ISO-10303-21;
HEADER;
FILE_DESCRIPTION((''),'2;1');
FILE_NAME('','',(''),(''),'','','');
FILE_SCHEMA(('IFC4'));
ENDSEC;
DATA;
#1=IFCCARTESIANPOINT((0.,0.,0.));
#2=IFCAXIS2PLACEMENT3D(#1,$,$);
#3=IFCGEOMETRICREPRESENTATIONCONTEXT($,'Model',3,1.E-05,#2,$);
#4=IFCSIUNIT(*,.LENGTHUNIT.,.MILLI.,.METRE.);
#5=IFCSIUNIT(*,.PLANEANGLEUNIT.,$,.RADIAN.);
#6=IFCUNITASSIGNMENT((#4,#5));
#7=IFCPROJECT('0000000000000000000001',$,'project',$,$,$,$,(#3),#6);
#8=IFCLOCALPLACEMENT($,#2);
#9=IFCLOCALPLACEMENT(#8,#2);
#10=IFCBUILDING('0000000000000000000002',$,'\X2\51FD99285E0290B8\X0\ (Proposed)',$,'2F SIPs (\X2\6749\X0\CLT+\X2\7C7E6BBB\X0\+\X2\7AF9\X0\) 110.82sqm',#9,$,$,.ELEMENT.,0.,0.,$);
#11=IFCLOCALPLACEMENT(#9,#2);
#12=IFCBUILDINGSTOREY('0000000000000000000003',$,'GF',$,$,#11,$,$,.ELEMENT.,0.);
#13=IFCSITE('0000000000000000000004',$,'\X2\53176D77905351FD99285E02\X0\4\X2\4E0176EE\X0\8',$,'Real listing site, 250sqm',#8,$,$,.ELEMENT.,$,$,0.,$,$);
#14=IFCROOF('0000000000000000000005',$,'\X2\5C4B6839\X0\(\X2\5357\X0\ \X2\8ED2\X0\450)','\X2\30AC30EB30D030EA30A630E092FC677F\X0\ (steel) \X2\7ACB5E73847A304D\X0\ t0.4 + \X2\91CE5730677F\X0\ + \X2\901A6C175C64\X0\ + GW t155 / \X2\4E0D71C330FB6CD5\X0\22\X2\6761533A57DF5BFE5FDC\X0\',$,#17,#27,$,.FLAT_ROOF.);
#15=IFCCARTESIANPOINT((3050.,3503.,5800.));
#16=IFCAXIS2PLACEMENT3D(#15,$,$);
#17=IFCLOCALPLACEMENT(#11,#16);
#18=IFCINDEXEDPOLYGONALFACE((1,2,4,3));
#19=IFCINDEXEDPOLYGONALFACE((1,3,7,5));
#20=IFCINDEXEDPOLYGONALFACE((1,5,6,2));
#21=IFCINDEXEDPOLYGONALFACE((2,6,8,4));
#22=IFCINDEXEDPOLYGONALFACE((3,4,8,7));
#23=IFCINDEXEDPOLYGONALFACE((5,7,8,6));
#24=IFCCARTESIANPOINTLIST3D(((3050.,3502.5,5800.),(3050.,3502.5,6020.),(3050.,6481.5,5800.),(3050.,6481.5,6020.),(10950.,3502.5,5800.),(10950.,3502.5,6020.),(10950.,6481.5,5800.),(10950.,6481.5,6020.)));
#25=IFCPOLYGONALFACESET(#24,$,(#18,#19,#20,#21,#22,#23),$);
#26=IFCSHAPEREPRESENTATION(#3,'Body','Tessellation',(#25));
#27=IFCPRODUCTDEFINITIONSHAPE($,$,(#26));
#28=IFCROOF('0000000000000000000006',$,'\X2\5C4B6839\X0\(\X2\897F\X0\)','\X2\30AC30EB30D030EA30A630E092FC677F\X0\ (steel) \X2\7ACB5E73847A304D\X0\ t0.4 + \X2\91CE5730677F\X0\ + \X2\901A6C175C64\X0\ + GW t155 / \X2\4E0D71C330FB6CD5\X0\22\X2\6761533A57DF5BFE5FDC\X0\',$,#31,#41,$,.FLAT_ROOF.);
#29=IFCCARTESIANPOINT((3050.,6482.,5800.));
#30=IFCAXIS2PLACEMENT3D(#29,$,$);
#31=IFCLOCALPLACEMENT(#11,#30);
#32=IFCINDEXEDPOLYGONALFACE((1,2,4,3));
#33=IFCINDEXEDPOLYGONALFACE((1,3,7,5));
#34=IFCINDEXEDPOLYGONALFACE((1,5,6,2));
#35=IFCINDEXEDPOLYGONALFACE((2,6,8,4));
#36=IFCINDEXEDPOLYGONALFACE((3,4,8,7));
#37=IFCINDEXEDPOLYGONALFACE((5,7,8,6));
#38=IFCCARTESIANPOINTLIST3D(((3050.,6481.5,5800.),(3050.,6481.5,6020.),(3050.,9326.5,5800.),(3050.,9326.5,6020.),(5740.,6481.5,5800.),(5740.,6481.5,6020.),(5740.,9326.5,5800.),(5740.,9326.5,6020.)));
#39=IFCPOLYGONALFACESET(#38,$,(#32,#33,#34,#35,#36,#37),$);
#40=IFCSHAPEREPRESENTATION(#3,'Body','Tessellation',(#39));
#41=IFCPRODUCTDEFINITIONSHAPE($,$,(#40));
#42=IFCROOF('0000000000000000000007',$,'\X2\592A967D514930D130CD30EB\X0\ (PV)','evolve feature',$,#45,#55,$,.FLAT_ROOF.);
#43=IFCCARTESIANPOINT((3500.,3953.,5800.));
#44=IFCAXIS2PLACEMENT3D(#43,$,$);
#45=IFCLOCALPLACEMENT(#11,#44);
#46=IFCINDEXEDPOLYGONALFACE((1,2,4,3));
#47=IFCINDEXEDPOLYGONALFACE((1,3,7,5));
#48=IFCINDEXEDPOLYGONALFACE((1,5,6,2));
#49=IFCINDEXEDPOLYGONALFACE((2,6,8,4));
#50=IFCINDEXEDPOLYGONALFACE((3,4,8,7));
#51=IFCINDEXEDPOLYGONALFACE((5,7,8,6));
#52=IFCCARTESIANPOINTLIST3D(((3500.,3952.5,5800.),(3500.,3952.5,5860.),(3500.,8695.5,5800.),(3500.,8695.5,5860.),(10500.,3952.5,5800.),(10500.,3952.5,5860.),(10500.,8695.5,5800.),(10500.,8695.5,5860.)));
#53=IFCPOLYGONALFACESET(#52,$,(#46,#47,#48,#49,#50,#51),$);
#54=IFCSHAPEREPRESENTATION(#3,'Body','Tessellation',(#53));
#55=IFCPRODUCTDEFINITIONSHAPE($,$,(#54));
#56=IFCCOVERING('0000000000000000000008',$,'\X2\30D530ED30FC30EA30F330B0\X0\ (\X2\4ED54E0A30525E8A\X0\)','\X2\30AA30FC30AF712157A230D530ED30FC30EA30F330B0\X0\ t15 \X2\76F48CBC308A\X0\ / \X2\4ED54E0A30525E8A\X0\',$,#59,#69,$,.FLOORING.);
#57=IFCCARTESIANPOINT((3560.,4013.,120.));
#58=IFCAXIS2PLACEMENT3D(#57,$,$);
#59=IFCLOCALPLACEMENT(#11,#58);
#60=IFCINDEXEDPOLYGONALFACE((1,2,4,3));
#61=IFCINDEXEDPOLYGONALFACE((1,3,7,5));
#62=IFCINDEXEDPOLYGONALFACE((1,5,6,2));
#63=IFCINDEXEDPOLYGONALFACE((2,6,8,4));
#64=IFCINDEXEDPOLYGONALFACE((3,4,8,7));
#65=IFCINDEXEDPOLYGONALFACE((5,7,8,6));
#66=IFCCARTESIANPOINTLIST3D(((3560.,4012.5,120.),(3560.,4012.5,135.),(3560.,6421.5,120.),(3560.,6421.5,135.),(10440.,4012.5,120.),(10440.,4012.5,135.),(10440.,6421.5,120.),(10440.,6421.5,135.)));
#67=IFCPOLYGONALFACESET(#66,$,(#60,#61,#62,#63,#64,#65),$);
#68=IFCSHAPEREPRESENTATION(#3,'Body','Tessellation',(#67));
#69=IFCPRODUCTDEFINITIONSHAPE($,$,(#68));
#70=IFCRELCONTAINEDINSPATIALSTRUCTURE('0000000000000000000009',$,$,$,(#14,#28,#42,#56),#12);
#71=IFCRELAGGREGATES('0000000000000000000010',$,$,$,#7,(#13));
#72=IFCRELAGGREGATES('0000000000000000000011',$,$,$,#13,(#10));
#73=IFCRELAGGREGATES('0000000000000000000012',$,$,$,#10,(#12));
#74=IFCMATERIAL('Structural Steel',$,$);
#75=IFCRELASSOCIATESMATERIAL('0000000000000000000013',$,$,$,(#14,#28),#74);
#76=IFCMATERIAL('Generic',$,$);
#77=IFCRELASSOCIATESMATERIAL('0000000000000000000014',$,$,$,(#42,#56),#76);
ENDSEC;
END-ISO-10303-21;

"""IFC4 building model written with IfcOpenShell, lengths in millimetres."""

from ifc_helpers import new_model, si_unit, frame, frame_2d, origin, place, context, project, spatial, rectangle, extrude, material, element, save


model = new_model("IFC4")

# Units and contexts
model_context = context("Model", 3, precision=1e-05, world=origin())
ifc_project = project(units=[si_unit("LENGTHUNIT", "METRE", prefix="MILLI"), si_unit("PLANEANGLEUNIT", "RADIAN")], contexts=[model_context])

# Site, building, storey
site_placement = place(None, origin())
site = spatial("IfcSite", under=ifc_project, at=site_placement, Name="北海道函館市4丁目8", ObjectType="Real listing site, 250sqm", CompositionType="ELEMENT", RefElevation=0.0)
building_placement = place(site_placement, origin())
building = spatial("IfcBuilding", under=site, at=building_placement, Name="函館市邸 (Proposed)", ObjectType="2F SIPs (杉CLT+籾殻+竹) 110.82sqm", CompositionType="ELEMENT", ElevationOfRefHeight=0.0, ElevationOfTerrain=0.0)
storey_placement = place(building_placement, origin())
storey = spatial("IfcBuildingStorey", under=building, at=storey_placement, Name="GF", CompositionType="ELEMENT", Elevation=0.0)

# Shared definitions
ifc_material_1 = material(Name="Generic")

# Roofs
ifc_material_2 = material(Name="Structural Steel")
roof_1_placement = place(storey_placement, frame((3050.0, 3503.0, 5800.0)))
element("IfcRoof", 1, at=roof_1_placement, inside=storey, material=ifc_material_2, Name="屋根(南 軒450)", Description="ガルバリウム鋼板 (steel) 立平葺き t0.4 + 野地板 + 通気層 + GW t155 / 不燃・法22条区域対応", PredefinedType="FLAT_ROOF", context=model_context, shape_type="SweptSolid", body=[
    extrude(rectangle(XDim=7900.0, YDim=2979.0, at=frame_2d((3950.0, 1489.0))), frame((3050.0, 3503.0, 5800.0)), (0.0, 0.0, 1.0), 220.0),
])
roof_2_placement = place(storey_placement, frame((3050.0, 6482.0, 5800.0)))
element("IfcRoof", 2, at=roof_2_placement, inside=storey, material=ifc_material_2, Name="屋根(西)", Description="ガルバリウム鋼板 (steel) 立平葺き t0.4 + 野地板 + 通気層 + GW t155 / 不燃・法22条区域対応", PredefinedType="FLAT_ROOF", context=model_context, shape_type="SweptSolid", body=[
    extrude(rectangle(XDim=2690.0, YDim=2845.0, at=frame_2d((1345.0, 1422.0))), frame((3050.0, 6482.0, 5800.0)), (0.0, 0.0, 1.0), 220.0),
])
roof_3_placement = place(storey_placement, frame((3500.0, 3953.0, 5800.0)))
element("IfcRoof", 3, at=roof_3_placement, inside=storey, material=ifc_material_1, Name="太陽光パネル (PV)", Description="evolve feature", PredefinedType="FLAT_ROOF", context=model_context, shape_type="SweptSolid", body=[
    extrude(rectangle(XDim=7000.0, YDim=4743.0, at=frame_2d((3500.0, 2371.0))), frame((3500.0, 3953.0, 5800.0)), (0.0, 0.0, 1.0), 60.0),
])

# Covering
covering_placement = place(storey_placement, frame((3560.0, 4013.0, 120.0)))
element("IfcCovering", 4, at=covering_placement, inside=storey, material=ifc_material_1, Name="フローリング (仕上げ床)", Description="オーク無垢フローリング t15 直貼り / 仕上げ床", PredefinedType="FLOORING", context=model_context, shape_type="SweptSolid", body=[
    extrude(rectangle(XDim=6880.0, YDim=2409.0, at=frame_2d((3440.0, 1204.0))), frame((3560.0, 4013.0, 120.0)), (0.0, 0.0, 1.0), 15.0),
])

save(model, "model.ifc")
